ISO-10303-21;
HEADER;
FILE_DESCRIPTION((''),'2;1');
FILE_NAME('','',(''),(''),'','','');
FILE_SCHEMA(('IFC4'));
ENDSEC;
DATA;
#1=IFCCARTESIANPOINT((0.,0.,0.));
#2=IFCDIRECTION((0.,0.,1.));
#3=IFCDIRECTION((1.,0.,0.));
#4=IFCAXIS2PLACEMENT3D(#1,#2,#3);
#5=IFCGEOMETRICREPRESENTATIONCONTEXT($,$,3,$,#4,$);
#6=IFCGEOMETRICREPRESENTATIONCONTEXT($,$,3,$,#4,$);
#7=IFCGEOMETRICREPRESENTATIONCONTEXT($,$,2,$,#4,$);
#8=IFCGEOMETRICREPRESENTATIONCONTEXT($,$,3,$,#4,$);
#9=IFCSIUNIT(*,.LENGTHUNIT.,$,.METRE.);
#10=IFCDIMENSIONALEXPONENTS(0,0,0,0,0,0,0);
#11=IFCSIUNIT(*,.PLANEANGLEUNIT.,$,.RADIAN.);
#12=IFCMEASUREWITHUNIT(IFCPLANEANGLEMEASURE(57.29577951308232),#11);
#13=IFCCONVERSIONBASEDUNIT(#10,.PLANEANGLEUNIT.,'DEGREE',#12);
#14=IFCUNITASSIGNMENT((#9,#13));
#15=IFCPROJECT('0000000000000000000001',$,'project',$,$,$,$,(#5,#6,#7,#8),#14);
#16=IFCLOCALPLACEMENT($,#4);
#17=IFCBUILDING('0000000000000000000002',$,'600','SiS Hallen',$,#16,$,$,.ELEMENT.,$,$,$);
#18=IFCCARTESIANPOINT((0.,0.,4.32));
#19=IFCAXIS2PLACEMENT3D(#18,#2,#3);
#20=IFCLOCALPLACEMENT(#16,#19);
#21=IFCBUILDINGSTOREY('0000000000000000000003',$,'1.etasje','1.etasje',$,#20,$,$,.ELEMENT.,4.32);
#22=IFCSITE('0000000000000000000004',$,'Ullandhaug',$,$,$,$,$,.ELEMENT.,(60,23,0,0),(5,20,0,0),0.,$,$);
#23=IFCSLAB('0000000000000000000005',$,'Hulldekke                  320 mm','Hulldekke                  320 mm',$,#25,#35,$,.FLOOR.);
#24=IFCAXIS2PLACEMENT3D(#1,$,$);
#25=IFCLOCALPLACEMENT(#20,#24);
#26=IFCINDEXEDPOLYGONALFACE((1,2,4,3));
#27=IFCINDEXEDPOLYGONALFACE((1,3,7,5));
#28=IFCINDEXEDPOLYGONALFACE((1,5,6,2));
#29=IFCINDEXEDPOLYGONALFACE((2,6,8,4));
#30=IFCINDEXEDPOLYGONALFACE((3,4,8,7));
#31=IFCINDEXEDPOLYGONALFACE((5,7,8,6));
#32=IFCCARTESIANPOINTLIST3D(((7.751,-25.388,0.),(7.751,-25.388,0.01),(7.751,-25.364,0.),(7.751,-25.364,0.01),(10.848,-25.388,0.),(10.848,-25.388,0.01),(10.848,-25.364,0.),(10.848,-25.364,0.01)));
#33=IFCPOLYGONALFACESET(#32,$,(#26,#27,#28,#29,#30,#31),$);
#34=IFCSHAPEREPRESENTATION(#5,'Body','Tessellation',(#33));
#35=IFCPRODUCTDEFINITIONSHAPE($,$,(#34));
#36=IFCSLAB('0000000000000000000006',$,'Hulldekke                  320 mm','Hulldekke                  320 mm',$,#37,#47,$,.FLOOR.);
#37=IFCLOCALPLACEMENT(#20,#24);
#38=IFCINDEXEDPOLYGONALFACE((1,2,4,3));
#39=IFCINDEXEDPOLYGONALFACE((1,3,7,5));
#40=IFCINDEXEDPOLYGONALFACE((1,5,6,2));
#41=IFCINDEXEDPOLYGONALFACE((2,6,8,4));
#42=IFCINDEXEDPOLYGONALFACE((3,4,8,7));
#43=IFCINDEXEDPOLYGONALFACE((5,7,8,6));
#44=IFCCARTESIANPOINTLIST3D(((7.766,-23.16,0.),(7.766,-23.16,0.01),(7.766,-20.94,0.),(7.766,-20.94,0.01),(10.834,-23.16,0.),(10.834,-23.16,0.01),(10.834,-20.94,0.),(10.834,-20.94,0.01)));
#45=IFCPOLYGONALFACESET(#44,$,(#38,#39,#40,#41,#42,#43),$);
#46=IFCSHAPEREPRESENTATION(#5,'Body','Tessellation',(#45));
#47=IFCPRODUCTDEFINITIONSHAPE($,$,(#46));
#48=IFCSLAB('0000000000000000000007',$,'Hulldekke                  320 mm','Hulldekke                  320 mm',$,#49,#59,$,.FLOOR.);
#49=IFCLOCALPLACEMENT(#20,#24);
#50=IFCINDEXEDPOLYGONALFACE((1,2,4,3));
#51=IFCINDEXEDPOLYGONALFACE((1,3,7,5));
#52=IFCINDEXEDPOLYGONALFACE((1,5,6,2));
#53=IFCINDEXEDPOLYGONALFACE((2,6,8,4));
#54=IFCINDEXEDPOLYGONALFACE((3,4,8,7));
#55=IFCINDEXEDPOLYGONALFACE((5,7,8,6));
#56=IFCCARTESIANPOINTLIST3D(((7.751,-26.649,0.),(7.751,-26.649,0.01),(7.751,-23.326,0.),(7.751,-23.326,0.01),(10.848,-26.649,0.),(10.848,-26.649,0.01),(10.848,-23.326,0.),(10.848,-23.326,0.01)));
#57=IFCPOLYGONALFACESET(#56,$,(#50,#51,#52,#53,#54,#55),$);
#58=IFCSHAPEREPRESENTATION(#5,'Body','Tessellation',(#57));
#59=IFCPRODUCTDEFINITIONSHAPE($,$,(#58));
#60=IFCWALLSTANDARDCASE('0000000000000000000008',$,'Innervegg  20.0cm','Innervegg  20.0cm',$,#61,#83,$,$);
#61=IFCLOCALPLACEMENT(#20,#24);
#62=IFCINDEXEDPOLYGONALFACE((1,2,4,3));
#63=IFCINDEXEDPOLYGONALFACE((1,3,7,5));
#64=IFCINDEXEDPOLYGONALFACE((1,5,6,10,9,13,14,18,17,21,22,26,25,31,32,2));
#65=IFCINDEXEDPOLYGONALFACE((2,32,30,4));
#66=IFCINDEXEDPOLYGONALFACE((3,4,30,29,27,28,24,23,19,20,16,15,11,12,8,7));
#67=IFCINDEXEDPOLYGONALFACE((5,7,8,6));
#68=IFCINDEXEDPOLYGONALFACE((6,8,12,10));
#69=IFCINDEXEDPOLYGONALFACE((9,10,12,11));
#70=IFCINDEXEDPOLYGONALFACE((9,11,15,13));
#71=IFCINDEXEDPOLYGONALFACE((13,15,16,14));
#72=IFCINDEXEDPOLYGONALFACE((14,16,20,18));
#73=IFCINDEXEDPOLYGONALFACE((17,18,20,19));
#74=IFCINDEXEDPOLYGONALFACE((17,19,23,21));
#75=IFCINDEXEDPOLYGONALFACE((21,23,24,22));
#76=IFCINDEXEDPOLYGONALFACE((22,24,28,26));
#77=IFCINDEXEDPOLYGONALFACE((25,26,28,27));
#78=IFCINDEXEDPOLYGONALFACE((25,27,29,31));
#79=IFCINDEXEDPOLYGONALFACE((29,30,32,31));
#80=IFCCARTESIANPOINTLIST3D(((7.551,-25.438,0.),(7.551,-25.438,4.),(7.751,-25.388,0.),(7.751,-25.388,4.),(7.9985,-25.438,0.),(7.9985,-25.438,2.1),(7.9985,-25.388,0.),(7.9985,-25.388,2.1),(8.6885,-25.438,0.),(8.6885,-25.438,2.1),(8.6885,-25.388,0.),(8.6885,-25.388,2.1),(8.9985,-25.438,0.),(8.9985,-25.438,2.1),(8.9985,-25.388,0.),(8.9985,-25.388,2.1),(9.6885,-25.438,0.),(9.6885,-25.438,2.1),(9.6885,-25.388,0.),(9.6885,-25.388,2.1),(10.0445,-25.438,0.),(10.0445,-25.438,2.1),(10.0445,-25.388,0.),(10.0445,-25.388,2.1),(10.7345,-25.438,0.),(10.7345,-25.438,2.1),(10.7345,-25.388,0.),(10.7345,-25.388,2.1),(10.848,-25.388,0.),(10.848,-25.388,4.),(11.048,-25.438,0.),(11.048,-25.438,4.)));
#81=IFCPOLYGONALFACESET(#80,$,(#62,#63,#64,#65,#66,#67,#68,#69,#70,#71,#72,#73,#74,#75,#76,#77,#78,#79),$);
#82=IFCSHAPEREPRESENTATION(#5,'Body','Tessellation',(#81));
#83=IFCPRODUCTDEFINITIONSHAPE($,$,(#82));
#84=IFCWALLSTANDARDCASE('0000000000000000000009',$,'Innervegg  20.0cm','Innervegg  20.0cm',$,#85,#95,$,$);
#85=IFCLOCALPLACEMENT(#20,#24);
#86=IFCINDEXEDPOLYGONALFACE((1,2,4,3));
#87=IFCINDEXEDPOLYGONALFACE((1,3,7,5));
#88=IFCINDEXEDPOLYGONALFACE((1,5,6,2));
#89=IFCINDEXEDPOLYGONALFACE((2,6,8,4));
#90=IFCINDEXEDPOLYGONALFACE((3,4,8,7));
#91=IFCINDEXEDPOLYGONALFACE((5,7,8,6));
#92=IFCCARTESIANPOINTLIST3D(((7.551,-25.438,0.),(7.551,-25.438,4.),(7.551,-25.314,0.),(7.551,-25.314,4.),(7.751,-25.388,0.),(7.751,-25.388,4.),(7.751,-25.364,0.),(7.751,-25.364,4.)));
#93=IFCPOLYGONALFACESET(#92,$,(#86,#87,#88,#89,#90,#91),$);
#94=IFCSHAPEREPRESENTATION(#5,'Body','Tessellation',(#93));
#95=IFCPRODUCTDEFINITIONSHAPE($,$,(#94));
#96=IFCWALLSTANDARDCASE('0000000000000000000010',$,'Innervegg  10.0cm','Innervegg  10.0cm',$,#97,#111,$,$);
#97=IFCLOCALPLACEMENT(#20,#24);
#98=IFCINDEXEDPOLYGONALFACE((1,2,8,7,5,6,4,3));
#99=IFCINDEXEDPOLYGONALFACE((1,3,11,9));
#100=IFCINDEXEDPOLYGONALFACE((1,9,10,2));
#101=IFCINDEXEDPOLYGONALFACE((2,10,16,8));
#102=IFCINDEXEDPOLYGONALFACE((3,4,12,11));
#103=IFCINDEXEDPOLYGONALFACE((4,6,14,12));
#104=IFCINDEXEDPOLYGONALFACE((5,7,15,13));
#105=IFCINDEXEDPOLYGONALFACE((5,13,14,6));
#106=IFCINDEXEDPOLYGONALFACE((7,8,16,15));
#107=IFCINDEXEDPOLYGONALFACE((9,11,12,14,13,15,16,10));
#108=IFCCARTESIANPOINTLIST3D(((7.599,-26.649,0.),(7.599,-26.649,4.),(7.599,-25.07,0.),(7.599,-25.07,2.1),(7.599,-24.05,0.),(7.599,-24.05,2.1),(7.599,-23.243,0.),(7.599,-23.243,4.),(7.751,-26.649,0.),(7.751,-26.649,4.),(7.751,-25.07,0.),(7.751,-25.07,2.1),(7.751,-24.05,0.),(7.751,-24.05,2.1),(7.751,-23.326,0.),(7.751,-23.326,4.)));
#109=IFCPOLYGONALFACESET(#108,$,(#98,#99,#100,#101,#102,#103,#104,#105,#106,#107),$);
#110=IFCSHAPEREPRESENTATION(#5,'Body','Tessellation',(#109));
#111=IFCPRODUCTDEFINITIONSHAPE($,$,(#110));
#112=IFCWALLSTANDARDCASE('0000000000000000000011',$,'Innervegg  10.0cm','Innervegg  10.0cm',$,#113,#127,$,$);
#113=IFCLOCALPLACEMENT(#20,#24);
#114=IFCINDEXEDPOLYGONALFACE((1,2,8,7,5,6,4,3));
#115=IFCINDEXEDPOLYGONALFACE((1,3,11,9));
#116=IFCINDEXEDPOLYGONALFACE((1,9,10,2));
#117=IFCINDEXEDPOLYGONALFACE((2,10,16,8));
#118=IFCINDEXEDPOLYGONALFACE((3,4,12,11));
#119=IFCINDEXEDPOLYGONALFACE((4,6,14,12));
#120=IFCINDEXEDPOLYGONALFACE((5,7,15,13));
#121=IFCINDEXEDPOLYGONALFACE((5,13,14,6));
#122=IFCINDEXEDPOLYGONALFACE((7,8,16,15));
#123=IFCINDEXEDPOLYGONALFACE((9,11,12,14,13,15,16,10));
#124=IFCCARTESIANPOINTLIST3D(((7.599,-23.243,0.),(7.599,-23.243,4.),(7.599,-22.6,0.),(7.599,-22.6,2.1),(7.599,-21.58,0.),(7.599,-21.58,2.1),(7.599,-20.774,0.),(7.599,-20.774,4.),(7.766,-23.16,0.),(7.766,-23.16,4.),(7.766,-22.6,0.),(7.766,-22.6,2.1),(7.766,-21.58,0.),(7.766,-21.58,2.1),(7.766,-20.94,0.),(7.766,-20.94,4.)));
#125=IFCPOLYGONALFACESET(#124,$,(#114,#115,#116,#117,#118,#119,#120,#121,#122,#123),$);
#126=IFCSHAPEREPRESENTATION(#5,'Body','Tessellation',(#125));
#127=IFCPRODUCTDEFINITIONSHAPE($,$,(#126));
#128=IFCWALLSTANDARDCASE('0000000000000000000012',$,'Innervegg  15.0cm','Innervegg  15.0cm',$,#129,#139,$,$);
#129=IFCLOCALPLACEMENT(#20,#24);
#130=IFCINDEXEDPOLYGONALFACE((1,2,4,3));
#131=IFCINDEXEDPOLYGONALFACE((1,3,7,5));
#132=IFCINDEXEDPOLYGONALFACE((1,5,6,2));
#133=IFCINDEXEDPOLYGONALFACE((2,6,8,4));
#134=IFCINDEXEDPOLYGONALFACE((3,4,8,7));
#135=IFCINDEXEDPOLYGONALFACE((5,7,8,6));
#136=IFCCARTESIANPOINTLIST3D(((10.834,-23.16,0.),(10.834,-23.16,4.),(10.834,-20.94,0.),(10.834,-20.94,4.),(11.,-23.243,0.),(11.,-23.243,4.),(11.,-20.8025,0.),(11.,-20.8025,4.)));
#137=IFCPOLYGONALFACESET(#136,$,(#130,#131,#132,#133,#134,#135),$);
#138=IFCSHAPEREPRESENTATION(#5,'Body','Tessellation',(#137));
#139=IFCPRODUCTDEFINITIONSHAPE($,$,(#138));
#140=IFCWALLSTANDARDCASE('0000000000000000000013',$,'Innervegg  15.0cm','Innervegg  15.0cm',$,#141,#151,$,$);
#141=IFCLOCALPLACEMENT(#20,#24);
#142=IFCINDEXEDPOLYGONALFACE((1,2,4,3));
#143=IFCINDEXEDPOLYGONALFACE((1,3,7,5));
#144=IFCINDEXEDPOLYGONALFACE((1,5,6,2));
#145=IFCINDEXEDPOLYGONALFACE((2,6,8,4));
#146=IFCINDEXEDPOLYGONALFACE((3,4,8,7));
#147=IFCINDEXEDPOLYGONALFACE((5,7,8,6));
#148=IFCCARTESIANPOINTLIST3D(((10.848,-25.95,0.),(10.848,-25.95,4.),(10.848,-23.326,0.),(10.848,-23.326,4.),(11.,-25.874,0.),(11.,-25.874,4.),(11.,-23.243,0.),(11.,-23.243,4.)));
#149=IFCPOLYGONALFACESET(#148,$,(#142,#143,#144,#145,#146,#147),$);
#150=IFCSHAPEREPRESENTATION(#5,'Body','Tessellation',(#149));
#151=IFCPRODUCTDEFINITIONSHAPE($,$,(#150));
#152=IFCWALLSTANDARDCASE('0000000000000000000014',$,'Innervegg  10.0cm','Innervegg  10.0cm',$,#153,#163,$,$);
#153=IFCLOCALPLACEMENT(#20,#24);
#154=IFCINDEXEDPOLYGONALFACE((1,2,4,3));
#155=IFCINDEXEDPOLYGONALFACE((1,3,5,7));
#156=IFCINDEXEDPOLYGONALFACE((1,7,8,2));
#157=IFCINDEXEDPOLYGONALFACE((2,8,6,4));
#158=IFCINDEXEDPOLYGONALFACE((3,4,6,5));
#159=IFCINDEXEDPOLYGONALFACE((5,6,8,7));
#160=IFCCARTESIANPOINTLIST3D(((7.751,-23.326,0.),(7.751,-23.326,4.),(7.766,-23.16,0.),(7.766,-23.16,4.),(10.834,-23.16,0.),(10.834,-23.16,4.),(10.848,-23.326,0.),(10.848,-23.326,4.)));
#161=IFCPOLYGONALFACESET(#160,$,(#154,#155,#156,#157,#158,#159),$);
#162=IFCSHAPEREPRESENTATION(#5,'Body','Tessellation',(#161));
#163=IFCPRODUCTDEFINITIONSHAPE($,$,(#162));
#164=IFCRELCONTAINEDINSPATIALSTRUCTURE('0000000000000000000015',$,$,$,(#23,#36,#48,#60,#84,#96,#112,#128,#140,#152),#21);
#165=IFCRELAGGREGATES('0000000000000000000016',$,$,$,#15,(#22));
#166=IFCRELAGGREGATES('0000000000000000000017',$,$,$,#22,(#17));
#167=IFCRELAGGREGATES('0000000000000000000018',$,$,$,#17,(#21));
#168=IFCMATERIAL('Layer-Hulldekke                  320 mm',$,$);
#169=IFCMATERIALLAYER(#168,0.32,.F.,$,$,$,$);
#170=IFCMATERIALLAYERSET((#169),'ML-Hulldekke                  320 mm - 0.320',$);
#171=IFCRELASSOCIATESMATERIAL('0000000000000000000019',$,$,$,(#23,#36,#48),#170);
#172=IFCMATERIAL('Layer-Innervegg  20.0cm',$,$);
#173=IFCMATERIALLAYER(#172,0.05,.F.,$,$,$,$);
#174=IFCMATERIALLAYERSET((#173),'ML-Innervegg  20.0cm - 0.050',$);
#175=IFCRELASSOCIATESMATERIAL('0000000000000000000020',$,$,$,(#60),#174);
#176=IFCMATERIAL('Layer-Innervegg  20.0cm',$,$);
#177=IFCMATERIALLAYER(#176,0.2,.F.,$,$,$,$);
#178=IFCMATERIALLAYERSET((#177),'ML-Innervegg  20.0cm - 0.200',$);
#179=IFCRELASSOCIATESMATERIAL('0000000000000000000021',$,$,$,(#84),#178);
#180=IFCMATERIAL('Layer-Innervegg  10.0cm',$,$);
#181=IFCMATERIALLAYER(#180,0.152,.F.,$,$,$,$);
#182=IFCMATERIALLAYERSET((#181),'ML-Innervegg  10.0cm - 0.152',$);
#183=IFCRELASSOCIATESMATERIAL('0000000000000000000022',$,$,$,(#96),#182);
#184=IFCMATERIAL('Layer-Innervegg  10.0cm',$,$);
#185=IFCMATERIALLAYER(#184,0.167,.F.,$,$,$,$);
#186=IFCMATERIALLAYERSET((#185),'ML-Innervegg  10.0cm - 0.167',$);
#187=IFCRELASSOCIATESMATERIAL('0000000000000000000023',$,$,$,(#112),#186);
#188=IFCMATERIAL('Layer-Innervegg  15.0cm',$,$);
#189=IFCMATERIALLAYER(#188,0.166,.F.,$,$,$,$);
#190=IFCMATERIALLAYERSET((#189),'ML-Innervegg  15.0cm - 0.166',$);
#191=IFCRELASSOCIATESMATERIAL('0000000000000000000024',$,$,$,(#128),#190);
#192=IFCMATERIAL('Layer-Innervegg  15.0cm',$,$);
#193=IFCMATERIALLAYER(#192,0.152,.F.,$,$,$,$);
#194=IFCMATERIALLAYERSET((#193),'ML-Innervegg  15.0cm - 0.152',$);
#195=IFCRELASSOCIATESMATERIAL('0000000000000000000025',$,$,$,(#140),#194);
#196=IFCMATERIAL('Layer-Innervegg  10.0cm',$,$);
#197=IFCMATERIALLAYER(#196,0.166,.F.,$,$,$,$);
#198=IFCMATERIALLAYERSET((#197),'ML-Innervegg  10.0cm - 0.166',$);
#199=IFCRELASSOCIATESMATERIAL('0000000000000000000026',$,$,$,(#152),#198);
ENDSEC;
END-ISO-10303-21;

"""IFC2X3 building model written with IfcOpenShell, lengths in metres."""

from ifc_helpers import new_model, entity, si_unit, converted_unit, frame, origin_with_axes, place, context, project, spatial, polyline, outline, extrude, material, layer, layer_set, layer_usage, element, save


model = new_model("IFC2X3")

# Units and contexts
context_of_model_1 = context(None, 3, world=origin_with_axes())
context_of_model_2 = context(None, 3, world=origin_with_axes())
context_of_model_3 = context(None, 2, world=origin_with_axes())
context_of_model_4 = context(None, 3, world=origin_with_axes())
ifc_project = project(units=[si_unit("LENGTHUNIT", "METRE"), converted_unit("PLANEANGLEUNIT", "DEGREE", entity("IfcPlaneAngleMeasure", 57.29577951308232), si_unit("PLANEANGLEUNIT", "RADIAN"), dimensions=[0, 0, 0, 0, 0, 0, 0])], contexts=[context_of_model_1, context_of_model_2, context_of_model_3, context_of_model_4])

# Site, building, storey
site = spatial("IfcSite", under=ifc_project, Name="Ullandhaug", CompositionType="ELEMENT", RefLatitude=(60, 23, 0, 0), RefLongitude=(5, 20, 0, 0), RefElevation=0.0)
building_placement = place(None, origin_with_axes())
building = spatial("IfcBuilding", under=site, at=building_placement, Name="600", Description="SiS Hallen", CompositionType="ELEMENT")
storey_placement = place(building_placement, frame((0.0, 0.0, 4.32), z_axis=(0.0, 0.0, 1.0), x_axis=(1.0, 0.0, 0.0)))
storey = spatial("IfcBuildingStorey", under=building, at=storey_placement, Name="1.etasje", Description="1.etasje", CompositionType="ELEMENT", Elevation=4.32)

# Slabs
ifc_material_1 = material(Name="Layer-Hulldekke                  320 mm")
ifc_layer_1 = layer(ifc_material_1, 0.32, ventilated=False)
ifc_layer_set_1 = layer_set([ifc_layer_1], Name="ML-Hulldekke                  320 mm - 0.320")
ifc_layer_usage_1 = layer_usage(ifc_layer_set_1, "AXIS2", "POSITIVE", 0.0)
slab_1_placement = place(storey_placement, frame((7.751, -25.388, 0.0), z_axis=(0.0, 0.0, 1.0), x_axis=(1.0, 0.0, 0.0)))
element("IfcSlab", 1, at=slab_1_placement, inside=storey, material=ifc_layer_usage_1, Name="Hulldekke                  320 mm", Description="Hulldekke                  320 mm", PredefinedType="FLOOR", context=context_of_model_1, shape_type="SweptSolid", body=[
    extrude(outline(polyline([(0.0, 0.0), (3.097, 0.0), (3.097, 0.024), (0.0, 0.024), (0.0, 0.0)])), origin_with_axes(), (0.0, 0.0, 1.0), 0.01),
])
slab_2_placement = place(storey_placement, frame((7.766, -23.16, 0.0), z_axis=(0.0, 0.0, 1.0), x_axis=(1.0, 0.0, 0.0)))
element("IfcSlab", 2, at=slab_2_placement, inside=storey, material=ifc_layer_usage_1, Name="Hulldekke                  320 mm", Description="Hulldekke                  320 mm", PredefinedType="FLOOR", context=context_of_model_1, shape_type="SweptSolid", body=[
    extrude(outline(polyline([(0.0, 0.0), (3.068, 0.0), (3.068, 2.22), (0.0, 2.22), (0.0, 0.0)])), origin_with_axes(), (0.0, 0.0, 1.0), 0.01),
])
slab_3_placement = place(storey_placement, frame((7.751, -26.649, 0.0), z_axis=(0.0, 0.0, 1.0), x_axis=(1.0, 0.0, 0.0)))
element("IfcSlab", 3, at=slab_3_placement, inside=storey, material=ifc_layer_usage_1, Name="Hulldekke                  320 mm", Description="Hulldekke                  320 mm", PredefinedType="FLOOR", context=context_of_model_1, shape_type="SweptSolid", body=[
    extrude(outline(polyline([(0.0, 0.0), (3.097, 0.0), (3.097, 3.323), (0.0, 3.323), (0.0, 0.0)])), origin_with_axes(), (0.0, 0.0, 1.0), 0.01),
])

# Wall, openings
ifc_material_2 = material(Name="Layer-Innervegg  20.0cm")
ifc_layer_2 = layer(ifc_material_2, 0.05, ventilated=False)
ifc_layer_set_2 = layer_set([ifc_layer_2], Name="ML-Innervegg  20.0cm - 0.050")
ifc_layer_usage_2 = layer_usage(ifc_layer_set_2, "AXIS2", "POSITIVE", 0.0)
wall_1_placement = place(storey_placement, frame((7.551, -25.438, 0.0), z_axis=(0.0, 0.0, 1.0), x_axis=(1.0, 0.0, 0.0)))
wall_1 = element("IfcWallStandardCase", 4, at=wall_1_placement, inside=storey, material=ifc_layer_usage_2, Name="Innervegg  20.0cm", Description="Innervegg  20.0cm", context=context_of_model_1, shape_type="SweptSolid", body=[
    extrude(outline(polyline([(0.0, 0.0), (3.497, 0.0), (3.297, 0.05), (0.2, 0.05), (0.0, 0.0)])), origin_with_axes(), (0.0, 0.0, 1.0), 4.0),
])
opening_1_placement = place(wall_1_placement, frame((0.4475, 0.05, 0.0), z_axis=(0.0, 0.0, 1.0), x_axis=(1.0, 0.0, 0.0)))
element("IfcOpeningElement", 5, at=opening_1_placement, cuts=wall_1, context=context_of_model_1, shape_type="SweptSolid", body=[
    extrude(outline(polyline([(0.0, 0.0), (2.1, 0.0), (2.1, 0.69), (0.0, 0.69), (0.0, 0.0)])), frame((0.0, 0.0, 0.0), z_axis=(0.0, 1.0, 0.0), x_axis=(0.0, 0.0, 1.0)), (0.0, 0.0, -1.0), 0.05),
])
opening_2_placement = place(wall_1_placement, frame((1.4475, 0.05, 0.0), z_axis=(0.0, 0.0, 1.0), x_axis=(1.0, 0.0, 0.0)))
element("IfcOpeningElement", 6, at=opening_2_placement, cuts=wall_1, context=context_of_model_1, shape_type="SweptSolid", body=[
    extrude(outline(polyline([(0.0, 0.0), (2.1, 0.0), (2.1, 0.69), (0.0, 0.69), (0.0, 0.0)])), frame((0.0, 0.0, 0.0), z_axis=(0.0, 1.0, 0.0), x_axis=(0.0, 0.0, 1.0)), (0.0, 0.0, -1.0), 0.05),
])
opening_3_placement = place(wall_1_placement, frame((2.4935, 0.05, 0.0), z_axis=(0.0, 0.0, 1.0), x_axis=(1.0, 0.0, 0.0)))
element("IfcOpeningElement", 7, at=opening_3_placement, cuts=wall_1, context=context_of_model_1, shape_type="SweptSolid", body=[
    extrude(outline(polyline([(0.0, 0.0), (2.1, 0.0), (2.1, 0.69), (0.0, 0.69), (0.0, 0.0)])), frame((0.0, 0.0, 0.0), z_axis=(0.0, 1.0, 0.0), x_axis=(0.0, 0.0, 1.0)), (0.0, 0.0, -1.0), 0.05),
])

# Wall
ifc_material_3 = material(Name="Layer-Innervegg  20.0cm")
ifc_layer_3 = layer(ifc_material_3, 0.2, ventilated=False)
ifc_layer_set_3 = layer_set([ifc_layer_3], Name="ML-Innervegg  20.0cm - 0.200")
ifc_layer_usage_3 = layer_usage(ifc_layer_set_3, "AXIS2", "POSITIVE", 0.0)
wall_2_placement = place(storey_placement, frame((7.551, -25.314, 0.0), z_axis=(0.0, 0.0, 1.0), x_axis=(0.0, -1.0, 0.0)))
element("IfcWallStandardCase", 8, at=wall_2_placement, inside=storey, material=ifc_layer_usage_3, Name="Innervegg  20.0cm", Description="Innervegg  20.0cm", context=context_of_model_1, shape_type="SweptSolid", body=[
    extrude(outline(polyline([(0.0, 0.0), (0.124, 0.0), (0.074, 0.2), (0.05, 0.2), (0.0, 0.0)])), frame((0.0, 0.0, 0.0), z_axis=(0.0, 0.0, 1.0), x_axis=(1.0, 0.0, 0.0)), (0.0, 0.0, 1.0), 4.0),
])

# Walls, openings
ifc_material_4 = material(Name="Layer-Innervegg  10.0cm")
ifc_layer_4 = layer(ifc_material_4, 0.152, ventilated=False)
ifc_layer_set_4 = layer_set([ifc_layer_4], Name="ML-Innervegg  10.0cm - 0.152")
ifc_layer_usage_4 = layer_usage(ifc_layer_set_4, "AXIS2", "POSITIVE", 0.0)
wall_3_placement = place(storey_placement, frame((7.751, -26.649, 0.0), z_axis=(0.0, 0.0, 1.0), x_axis=(0.0, 1.0, 0.0)))
wall_3 = element("IfcWallStandardCase", 9, at=wall_3_placement, inside=storey, material=ifc_layer_usage_4, Name="Innervegg  10.0cm", Description="Innervegg  10.0cm", context=context_of_model_1, shape_type="SweptSolid", body=[
    extrude(outline(polyline([(0.0, 0.0), (3.323, 0.0), (3.406, 0.152), (0.0, 0.152), (0.0, 0.0)])), frame((0.0, 0.0, 0.0), z_axis=(0.0, 0.0, 1.0), x_axis=(1.0, 0.0, 0.0)), (0.0, 0.0, 1.0), 4.0),
])
opening_4_placement = place(wall_3_placement, frame((1.579, 0.152, 0.0), z_axis=(0.0, 0.0, 1.0), x_axis=(1.0, 0.0, 0.0)))
element("IfcOpeningElement", 10, at=opening_4_placement, cuts=wall_3, context=context_of_model_1, shape_type="SweptSolid", body=[
    extrude(outline(polyline([(0.0, 0.0), (2.1, 0.0), (2.1, 1.02), (0.0, 1.02), (0.0, 0.0)])), frame((0.0, 0.0, 0.0), z_axis=(0.0, 1.0, 0.0), x_axis=(0.0, 0.0, 1.0)), (0.0, 0.0, -1.0), 0.152),
])
ifc_material_5 = material(Name="Layer-Innervegg  10.0cm")
ifc_layer_5 = layer(ifc_material_5, 0.167, ventilated=False)
ifc_layer_set_5 = layer_set([ifc_layer_5], Name="ML-Innervegg  10.0cm - 0.167")
ifc_layer_usage_5 = layer_usage(ifc_layer_set_5, "AXIS2", "POSITIVE", 0.0)
wall_4_placement = place(storey_placement, frame((7.766, -23.16, 0.0), z_axis=(0.0, 0.0, 1.0), x_axis=(0.0, 1.0, 0.0)))
wall_4 = element("IfcWallStandardCase", 11, at=wall_4_placement, inside=storey, material=ifc_layer_usage_5, Name="Innervegg  10.0cm", Description="Innervegg  10.0cm", context=context_of_model_1, shape_type="SweptSolid", body=[
    extrude(outline(polyline([(0.0, 0.0), (2.22, 0.0), (2.386, 0.167), (-0.083, 0.167), (0.0, 0.0)])), frame((0.0, 0.0, 0.0), z_axis=(0.0, 0.0, 1.0), x_axis=(1.0, 0.0, 0.0)), (0.0, 0.0, 1.0), 4.0),
])
opening_5_placement = place(wall_4_placement, frame((0.56, 0.167, 0.0), z_axis=(0.0, 0.0, 1.0), x_axis=(1.0, 0.0, 0.0)))
element("IfcOpeningElement", 12, at=opening_5_placement, cuts=wall_4, context=context_of_model_1, shape_type="SweptSolid", body=[
    extrude(outline(polyline([(0.0, 0.0), (2.1, 0.0), (2.1, 1.02), (0.0, 1.02), (0.0, 0.0)])), frame((0.0, 0.0, 0.0), z_axis=(0.0, 1.0, 0.0), x_axis=(0.0, 0.0, 1.0)), (0.0, 0.0, -1.0), 0.167),
])

# Walls
ifc_material_6 = material(Name="Layer-Innervegg  15.0cm")
ifc_layer_6 = layer(ifc_material_6, 0.166, ventilated=False)
ifc_layer_set_6 = layer_set([ifc_layer_6], Name="ML-Innervegg  15.0cm - 0.166")
ifc_layer_usage_6 = layer_usage(ifc_layer_set_6, "AXIS2", "POSITIVE", 0.0)
wall_5_placement = place(storey_placement, frame((10.834, -20.94, 0.0), z_axis=(0.0, 0.0, 1.0), x_axis=(0.0, -1.0, 0.0)))
element("IfcWallStandardCase", 13, at=wall_5_placement, inside=storey, material=ifc_layer_usage_6, Name="Innervegg  15.0cm", Description="Innervegg  15.0cm", context=context_of_model_1, shape_type="SweptSolid", body=[
    extrude(outline(polyline([(0.0, 0.0), (2.22, 0.0), (2.303, 0.166), (-0.1375, 0.166), (0.0, 0.0)])), frame((0.0, 0.0, 0.0), z_axis=(0.0, 0.0, 1.0), x_axis=(1.0, 0.0, 0.0)), (0.0, 0.0, 1.0), 4.0),
])
ifc_material_7 = material(Name="Layer-Innervegg  15.0cm")
ifc_layer_7 = layer(ifc_material_7, 0.152, ventilated=False)
ifc_layer_set_7 = layer_set([ifc_layer_7], Name="ML-Innervegg  15.0cm - 0.152")
ifc_layer_usage_7 = layer_usage(ifc_layer_set_7, "AXIS2", "POSITIVE", 0.0)
wall_6_placement = place(storey_placement, frame((10.848, -23.326, 0.0), z_axis=(0.0, 0.0, 1.0), x_axis=(0.0, -1.0, 0.0)))
element("IfcWallStandardCase", 14, at=wall_6_placement, inside=storey, material=ifc_layer_usage_7, Name="Innervegg  15.0cm", Description="Innervegg  15.0cm", context=context_of_model_1, shape_type="SweptSolid", body=[
    extrude(outline(polyline([(0.0, 0.0), (2.624, 0.0), (2.548, 0.152), (-0.083, 0.152), (0.0, 0.0)])), frame((0.0, 0.0, 0.0), z_axis=(0.0, 0.0, 1.0), x_axis=(1.0, 0.0, 0.0)), (0.0, 0.0, 1.0), 4.0),
])
ifc_material_8 = material(Name="Layer-Innervegg  10.0cm")
ifc_layer_8 = layer(ifc_material_8, 0.166, ventilated=False)
ifc_layer_set_8 = layer_set([ifc_layer_8], Name="ML-Innervegg  10.0cm - 0.166")
ifc_layer_usage_8 = layer_usage(ifc_layer_set_8, "AXIS2", "POSITIVE", 0.0)
wall_7_placement = place(storey_placement, frame((7.751, -23.326, 0.0), z_axis=(0.0, 0.0, 1.0), x_axis=(1.0, 0.0, 0.0)))
element("IfcWallStandardCase", 15, at=wall_7_placement, inside=storey, material=ifc_layer_usage_8, Name="Innervegg  10.0cm", Description="Innervegg  10.0cm", context=context_of_model_1, shape_type="SweptSolid", body=[
    extrude(outline(polyline([(0.0, 0.0), (3.097, 0.0), (3.083, 0.166), (0.015, 0.166), (0.0, 0.0)])), origin_with_axes(), (0.0, 0.0, 1.0), 4.0),
])

save(model, "model.ifc")
